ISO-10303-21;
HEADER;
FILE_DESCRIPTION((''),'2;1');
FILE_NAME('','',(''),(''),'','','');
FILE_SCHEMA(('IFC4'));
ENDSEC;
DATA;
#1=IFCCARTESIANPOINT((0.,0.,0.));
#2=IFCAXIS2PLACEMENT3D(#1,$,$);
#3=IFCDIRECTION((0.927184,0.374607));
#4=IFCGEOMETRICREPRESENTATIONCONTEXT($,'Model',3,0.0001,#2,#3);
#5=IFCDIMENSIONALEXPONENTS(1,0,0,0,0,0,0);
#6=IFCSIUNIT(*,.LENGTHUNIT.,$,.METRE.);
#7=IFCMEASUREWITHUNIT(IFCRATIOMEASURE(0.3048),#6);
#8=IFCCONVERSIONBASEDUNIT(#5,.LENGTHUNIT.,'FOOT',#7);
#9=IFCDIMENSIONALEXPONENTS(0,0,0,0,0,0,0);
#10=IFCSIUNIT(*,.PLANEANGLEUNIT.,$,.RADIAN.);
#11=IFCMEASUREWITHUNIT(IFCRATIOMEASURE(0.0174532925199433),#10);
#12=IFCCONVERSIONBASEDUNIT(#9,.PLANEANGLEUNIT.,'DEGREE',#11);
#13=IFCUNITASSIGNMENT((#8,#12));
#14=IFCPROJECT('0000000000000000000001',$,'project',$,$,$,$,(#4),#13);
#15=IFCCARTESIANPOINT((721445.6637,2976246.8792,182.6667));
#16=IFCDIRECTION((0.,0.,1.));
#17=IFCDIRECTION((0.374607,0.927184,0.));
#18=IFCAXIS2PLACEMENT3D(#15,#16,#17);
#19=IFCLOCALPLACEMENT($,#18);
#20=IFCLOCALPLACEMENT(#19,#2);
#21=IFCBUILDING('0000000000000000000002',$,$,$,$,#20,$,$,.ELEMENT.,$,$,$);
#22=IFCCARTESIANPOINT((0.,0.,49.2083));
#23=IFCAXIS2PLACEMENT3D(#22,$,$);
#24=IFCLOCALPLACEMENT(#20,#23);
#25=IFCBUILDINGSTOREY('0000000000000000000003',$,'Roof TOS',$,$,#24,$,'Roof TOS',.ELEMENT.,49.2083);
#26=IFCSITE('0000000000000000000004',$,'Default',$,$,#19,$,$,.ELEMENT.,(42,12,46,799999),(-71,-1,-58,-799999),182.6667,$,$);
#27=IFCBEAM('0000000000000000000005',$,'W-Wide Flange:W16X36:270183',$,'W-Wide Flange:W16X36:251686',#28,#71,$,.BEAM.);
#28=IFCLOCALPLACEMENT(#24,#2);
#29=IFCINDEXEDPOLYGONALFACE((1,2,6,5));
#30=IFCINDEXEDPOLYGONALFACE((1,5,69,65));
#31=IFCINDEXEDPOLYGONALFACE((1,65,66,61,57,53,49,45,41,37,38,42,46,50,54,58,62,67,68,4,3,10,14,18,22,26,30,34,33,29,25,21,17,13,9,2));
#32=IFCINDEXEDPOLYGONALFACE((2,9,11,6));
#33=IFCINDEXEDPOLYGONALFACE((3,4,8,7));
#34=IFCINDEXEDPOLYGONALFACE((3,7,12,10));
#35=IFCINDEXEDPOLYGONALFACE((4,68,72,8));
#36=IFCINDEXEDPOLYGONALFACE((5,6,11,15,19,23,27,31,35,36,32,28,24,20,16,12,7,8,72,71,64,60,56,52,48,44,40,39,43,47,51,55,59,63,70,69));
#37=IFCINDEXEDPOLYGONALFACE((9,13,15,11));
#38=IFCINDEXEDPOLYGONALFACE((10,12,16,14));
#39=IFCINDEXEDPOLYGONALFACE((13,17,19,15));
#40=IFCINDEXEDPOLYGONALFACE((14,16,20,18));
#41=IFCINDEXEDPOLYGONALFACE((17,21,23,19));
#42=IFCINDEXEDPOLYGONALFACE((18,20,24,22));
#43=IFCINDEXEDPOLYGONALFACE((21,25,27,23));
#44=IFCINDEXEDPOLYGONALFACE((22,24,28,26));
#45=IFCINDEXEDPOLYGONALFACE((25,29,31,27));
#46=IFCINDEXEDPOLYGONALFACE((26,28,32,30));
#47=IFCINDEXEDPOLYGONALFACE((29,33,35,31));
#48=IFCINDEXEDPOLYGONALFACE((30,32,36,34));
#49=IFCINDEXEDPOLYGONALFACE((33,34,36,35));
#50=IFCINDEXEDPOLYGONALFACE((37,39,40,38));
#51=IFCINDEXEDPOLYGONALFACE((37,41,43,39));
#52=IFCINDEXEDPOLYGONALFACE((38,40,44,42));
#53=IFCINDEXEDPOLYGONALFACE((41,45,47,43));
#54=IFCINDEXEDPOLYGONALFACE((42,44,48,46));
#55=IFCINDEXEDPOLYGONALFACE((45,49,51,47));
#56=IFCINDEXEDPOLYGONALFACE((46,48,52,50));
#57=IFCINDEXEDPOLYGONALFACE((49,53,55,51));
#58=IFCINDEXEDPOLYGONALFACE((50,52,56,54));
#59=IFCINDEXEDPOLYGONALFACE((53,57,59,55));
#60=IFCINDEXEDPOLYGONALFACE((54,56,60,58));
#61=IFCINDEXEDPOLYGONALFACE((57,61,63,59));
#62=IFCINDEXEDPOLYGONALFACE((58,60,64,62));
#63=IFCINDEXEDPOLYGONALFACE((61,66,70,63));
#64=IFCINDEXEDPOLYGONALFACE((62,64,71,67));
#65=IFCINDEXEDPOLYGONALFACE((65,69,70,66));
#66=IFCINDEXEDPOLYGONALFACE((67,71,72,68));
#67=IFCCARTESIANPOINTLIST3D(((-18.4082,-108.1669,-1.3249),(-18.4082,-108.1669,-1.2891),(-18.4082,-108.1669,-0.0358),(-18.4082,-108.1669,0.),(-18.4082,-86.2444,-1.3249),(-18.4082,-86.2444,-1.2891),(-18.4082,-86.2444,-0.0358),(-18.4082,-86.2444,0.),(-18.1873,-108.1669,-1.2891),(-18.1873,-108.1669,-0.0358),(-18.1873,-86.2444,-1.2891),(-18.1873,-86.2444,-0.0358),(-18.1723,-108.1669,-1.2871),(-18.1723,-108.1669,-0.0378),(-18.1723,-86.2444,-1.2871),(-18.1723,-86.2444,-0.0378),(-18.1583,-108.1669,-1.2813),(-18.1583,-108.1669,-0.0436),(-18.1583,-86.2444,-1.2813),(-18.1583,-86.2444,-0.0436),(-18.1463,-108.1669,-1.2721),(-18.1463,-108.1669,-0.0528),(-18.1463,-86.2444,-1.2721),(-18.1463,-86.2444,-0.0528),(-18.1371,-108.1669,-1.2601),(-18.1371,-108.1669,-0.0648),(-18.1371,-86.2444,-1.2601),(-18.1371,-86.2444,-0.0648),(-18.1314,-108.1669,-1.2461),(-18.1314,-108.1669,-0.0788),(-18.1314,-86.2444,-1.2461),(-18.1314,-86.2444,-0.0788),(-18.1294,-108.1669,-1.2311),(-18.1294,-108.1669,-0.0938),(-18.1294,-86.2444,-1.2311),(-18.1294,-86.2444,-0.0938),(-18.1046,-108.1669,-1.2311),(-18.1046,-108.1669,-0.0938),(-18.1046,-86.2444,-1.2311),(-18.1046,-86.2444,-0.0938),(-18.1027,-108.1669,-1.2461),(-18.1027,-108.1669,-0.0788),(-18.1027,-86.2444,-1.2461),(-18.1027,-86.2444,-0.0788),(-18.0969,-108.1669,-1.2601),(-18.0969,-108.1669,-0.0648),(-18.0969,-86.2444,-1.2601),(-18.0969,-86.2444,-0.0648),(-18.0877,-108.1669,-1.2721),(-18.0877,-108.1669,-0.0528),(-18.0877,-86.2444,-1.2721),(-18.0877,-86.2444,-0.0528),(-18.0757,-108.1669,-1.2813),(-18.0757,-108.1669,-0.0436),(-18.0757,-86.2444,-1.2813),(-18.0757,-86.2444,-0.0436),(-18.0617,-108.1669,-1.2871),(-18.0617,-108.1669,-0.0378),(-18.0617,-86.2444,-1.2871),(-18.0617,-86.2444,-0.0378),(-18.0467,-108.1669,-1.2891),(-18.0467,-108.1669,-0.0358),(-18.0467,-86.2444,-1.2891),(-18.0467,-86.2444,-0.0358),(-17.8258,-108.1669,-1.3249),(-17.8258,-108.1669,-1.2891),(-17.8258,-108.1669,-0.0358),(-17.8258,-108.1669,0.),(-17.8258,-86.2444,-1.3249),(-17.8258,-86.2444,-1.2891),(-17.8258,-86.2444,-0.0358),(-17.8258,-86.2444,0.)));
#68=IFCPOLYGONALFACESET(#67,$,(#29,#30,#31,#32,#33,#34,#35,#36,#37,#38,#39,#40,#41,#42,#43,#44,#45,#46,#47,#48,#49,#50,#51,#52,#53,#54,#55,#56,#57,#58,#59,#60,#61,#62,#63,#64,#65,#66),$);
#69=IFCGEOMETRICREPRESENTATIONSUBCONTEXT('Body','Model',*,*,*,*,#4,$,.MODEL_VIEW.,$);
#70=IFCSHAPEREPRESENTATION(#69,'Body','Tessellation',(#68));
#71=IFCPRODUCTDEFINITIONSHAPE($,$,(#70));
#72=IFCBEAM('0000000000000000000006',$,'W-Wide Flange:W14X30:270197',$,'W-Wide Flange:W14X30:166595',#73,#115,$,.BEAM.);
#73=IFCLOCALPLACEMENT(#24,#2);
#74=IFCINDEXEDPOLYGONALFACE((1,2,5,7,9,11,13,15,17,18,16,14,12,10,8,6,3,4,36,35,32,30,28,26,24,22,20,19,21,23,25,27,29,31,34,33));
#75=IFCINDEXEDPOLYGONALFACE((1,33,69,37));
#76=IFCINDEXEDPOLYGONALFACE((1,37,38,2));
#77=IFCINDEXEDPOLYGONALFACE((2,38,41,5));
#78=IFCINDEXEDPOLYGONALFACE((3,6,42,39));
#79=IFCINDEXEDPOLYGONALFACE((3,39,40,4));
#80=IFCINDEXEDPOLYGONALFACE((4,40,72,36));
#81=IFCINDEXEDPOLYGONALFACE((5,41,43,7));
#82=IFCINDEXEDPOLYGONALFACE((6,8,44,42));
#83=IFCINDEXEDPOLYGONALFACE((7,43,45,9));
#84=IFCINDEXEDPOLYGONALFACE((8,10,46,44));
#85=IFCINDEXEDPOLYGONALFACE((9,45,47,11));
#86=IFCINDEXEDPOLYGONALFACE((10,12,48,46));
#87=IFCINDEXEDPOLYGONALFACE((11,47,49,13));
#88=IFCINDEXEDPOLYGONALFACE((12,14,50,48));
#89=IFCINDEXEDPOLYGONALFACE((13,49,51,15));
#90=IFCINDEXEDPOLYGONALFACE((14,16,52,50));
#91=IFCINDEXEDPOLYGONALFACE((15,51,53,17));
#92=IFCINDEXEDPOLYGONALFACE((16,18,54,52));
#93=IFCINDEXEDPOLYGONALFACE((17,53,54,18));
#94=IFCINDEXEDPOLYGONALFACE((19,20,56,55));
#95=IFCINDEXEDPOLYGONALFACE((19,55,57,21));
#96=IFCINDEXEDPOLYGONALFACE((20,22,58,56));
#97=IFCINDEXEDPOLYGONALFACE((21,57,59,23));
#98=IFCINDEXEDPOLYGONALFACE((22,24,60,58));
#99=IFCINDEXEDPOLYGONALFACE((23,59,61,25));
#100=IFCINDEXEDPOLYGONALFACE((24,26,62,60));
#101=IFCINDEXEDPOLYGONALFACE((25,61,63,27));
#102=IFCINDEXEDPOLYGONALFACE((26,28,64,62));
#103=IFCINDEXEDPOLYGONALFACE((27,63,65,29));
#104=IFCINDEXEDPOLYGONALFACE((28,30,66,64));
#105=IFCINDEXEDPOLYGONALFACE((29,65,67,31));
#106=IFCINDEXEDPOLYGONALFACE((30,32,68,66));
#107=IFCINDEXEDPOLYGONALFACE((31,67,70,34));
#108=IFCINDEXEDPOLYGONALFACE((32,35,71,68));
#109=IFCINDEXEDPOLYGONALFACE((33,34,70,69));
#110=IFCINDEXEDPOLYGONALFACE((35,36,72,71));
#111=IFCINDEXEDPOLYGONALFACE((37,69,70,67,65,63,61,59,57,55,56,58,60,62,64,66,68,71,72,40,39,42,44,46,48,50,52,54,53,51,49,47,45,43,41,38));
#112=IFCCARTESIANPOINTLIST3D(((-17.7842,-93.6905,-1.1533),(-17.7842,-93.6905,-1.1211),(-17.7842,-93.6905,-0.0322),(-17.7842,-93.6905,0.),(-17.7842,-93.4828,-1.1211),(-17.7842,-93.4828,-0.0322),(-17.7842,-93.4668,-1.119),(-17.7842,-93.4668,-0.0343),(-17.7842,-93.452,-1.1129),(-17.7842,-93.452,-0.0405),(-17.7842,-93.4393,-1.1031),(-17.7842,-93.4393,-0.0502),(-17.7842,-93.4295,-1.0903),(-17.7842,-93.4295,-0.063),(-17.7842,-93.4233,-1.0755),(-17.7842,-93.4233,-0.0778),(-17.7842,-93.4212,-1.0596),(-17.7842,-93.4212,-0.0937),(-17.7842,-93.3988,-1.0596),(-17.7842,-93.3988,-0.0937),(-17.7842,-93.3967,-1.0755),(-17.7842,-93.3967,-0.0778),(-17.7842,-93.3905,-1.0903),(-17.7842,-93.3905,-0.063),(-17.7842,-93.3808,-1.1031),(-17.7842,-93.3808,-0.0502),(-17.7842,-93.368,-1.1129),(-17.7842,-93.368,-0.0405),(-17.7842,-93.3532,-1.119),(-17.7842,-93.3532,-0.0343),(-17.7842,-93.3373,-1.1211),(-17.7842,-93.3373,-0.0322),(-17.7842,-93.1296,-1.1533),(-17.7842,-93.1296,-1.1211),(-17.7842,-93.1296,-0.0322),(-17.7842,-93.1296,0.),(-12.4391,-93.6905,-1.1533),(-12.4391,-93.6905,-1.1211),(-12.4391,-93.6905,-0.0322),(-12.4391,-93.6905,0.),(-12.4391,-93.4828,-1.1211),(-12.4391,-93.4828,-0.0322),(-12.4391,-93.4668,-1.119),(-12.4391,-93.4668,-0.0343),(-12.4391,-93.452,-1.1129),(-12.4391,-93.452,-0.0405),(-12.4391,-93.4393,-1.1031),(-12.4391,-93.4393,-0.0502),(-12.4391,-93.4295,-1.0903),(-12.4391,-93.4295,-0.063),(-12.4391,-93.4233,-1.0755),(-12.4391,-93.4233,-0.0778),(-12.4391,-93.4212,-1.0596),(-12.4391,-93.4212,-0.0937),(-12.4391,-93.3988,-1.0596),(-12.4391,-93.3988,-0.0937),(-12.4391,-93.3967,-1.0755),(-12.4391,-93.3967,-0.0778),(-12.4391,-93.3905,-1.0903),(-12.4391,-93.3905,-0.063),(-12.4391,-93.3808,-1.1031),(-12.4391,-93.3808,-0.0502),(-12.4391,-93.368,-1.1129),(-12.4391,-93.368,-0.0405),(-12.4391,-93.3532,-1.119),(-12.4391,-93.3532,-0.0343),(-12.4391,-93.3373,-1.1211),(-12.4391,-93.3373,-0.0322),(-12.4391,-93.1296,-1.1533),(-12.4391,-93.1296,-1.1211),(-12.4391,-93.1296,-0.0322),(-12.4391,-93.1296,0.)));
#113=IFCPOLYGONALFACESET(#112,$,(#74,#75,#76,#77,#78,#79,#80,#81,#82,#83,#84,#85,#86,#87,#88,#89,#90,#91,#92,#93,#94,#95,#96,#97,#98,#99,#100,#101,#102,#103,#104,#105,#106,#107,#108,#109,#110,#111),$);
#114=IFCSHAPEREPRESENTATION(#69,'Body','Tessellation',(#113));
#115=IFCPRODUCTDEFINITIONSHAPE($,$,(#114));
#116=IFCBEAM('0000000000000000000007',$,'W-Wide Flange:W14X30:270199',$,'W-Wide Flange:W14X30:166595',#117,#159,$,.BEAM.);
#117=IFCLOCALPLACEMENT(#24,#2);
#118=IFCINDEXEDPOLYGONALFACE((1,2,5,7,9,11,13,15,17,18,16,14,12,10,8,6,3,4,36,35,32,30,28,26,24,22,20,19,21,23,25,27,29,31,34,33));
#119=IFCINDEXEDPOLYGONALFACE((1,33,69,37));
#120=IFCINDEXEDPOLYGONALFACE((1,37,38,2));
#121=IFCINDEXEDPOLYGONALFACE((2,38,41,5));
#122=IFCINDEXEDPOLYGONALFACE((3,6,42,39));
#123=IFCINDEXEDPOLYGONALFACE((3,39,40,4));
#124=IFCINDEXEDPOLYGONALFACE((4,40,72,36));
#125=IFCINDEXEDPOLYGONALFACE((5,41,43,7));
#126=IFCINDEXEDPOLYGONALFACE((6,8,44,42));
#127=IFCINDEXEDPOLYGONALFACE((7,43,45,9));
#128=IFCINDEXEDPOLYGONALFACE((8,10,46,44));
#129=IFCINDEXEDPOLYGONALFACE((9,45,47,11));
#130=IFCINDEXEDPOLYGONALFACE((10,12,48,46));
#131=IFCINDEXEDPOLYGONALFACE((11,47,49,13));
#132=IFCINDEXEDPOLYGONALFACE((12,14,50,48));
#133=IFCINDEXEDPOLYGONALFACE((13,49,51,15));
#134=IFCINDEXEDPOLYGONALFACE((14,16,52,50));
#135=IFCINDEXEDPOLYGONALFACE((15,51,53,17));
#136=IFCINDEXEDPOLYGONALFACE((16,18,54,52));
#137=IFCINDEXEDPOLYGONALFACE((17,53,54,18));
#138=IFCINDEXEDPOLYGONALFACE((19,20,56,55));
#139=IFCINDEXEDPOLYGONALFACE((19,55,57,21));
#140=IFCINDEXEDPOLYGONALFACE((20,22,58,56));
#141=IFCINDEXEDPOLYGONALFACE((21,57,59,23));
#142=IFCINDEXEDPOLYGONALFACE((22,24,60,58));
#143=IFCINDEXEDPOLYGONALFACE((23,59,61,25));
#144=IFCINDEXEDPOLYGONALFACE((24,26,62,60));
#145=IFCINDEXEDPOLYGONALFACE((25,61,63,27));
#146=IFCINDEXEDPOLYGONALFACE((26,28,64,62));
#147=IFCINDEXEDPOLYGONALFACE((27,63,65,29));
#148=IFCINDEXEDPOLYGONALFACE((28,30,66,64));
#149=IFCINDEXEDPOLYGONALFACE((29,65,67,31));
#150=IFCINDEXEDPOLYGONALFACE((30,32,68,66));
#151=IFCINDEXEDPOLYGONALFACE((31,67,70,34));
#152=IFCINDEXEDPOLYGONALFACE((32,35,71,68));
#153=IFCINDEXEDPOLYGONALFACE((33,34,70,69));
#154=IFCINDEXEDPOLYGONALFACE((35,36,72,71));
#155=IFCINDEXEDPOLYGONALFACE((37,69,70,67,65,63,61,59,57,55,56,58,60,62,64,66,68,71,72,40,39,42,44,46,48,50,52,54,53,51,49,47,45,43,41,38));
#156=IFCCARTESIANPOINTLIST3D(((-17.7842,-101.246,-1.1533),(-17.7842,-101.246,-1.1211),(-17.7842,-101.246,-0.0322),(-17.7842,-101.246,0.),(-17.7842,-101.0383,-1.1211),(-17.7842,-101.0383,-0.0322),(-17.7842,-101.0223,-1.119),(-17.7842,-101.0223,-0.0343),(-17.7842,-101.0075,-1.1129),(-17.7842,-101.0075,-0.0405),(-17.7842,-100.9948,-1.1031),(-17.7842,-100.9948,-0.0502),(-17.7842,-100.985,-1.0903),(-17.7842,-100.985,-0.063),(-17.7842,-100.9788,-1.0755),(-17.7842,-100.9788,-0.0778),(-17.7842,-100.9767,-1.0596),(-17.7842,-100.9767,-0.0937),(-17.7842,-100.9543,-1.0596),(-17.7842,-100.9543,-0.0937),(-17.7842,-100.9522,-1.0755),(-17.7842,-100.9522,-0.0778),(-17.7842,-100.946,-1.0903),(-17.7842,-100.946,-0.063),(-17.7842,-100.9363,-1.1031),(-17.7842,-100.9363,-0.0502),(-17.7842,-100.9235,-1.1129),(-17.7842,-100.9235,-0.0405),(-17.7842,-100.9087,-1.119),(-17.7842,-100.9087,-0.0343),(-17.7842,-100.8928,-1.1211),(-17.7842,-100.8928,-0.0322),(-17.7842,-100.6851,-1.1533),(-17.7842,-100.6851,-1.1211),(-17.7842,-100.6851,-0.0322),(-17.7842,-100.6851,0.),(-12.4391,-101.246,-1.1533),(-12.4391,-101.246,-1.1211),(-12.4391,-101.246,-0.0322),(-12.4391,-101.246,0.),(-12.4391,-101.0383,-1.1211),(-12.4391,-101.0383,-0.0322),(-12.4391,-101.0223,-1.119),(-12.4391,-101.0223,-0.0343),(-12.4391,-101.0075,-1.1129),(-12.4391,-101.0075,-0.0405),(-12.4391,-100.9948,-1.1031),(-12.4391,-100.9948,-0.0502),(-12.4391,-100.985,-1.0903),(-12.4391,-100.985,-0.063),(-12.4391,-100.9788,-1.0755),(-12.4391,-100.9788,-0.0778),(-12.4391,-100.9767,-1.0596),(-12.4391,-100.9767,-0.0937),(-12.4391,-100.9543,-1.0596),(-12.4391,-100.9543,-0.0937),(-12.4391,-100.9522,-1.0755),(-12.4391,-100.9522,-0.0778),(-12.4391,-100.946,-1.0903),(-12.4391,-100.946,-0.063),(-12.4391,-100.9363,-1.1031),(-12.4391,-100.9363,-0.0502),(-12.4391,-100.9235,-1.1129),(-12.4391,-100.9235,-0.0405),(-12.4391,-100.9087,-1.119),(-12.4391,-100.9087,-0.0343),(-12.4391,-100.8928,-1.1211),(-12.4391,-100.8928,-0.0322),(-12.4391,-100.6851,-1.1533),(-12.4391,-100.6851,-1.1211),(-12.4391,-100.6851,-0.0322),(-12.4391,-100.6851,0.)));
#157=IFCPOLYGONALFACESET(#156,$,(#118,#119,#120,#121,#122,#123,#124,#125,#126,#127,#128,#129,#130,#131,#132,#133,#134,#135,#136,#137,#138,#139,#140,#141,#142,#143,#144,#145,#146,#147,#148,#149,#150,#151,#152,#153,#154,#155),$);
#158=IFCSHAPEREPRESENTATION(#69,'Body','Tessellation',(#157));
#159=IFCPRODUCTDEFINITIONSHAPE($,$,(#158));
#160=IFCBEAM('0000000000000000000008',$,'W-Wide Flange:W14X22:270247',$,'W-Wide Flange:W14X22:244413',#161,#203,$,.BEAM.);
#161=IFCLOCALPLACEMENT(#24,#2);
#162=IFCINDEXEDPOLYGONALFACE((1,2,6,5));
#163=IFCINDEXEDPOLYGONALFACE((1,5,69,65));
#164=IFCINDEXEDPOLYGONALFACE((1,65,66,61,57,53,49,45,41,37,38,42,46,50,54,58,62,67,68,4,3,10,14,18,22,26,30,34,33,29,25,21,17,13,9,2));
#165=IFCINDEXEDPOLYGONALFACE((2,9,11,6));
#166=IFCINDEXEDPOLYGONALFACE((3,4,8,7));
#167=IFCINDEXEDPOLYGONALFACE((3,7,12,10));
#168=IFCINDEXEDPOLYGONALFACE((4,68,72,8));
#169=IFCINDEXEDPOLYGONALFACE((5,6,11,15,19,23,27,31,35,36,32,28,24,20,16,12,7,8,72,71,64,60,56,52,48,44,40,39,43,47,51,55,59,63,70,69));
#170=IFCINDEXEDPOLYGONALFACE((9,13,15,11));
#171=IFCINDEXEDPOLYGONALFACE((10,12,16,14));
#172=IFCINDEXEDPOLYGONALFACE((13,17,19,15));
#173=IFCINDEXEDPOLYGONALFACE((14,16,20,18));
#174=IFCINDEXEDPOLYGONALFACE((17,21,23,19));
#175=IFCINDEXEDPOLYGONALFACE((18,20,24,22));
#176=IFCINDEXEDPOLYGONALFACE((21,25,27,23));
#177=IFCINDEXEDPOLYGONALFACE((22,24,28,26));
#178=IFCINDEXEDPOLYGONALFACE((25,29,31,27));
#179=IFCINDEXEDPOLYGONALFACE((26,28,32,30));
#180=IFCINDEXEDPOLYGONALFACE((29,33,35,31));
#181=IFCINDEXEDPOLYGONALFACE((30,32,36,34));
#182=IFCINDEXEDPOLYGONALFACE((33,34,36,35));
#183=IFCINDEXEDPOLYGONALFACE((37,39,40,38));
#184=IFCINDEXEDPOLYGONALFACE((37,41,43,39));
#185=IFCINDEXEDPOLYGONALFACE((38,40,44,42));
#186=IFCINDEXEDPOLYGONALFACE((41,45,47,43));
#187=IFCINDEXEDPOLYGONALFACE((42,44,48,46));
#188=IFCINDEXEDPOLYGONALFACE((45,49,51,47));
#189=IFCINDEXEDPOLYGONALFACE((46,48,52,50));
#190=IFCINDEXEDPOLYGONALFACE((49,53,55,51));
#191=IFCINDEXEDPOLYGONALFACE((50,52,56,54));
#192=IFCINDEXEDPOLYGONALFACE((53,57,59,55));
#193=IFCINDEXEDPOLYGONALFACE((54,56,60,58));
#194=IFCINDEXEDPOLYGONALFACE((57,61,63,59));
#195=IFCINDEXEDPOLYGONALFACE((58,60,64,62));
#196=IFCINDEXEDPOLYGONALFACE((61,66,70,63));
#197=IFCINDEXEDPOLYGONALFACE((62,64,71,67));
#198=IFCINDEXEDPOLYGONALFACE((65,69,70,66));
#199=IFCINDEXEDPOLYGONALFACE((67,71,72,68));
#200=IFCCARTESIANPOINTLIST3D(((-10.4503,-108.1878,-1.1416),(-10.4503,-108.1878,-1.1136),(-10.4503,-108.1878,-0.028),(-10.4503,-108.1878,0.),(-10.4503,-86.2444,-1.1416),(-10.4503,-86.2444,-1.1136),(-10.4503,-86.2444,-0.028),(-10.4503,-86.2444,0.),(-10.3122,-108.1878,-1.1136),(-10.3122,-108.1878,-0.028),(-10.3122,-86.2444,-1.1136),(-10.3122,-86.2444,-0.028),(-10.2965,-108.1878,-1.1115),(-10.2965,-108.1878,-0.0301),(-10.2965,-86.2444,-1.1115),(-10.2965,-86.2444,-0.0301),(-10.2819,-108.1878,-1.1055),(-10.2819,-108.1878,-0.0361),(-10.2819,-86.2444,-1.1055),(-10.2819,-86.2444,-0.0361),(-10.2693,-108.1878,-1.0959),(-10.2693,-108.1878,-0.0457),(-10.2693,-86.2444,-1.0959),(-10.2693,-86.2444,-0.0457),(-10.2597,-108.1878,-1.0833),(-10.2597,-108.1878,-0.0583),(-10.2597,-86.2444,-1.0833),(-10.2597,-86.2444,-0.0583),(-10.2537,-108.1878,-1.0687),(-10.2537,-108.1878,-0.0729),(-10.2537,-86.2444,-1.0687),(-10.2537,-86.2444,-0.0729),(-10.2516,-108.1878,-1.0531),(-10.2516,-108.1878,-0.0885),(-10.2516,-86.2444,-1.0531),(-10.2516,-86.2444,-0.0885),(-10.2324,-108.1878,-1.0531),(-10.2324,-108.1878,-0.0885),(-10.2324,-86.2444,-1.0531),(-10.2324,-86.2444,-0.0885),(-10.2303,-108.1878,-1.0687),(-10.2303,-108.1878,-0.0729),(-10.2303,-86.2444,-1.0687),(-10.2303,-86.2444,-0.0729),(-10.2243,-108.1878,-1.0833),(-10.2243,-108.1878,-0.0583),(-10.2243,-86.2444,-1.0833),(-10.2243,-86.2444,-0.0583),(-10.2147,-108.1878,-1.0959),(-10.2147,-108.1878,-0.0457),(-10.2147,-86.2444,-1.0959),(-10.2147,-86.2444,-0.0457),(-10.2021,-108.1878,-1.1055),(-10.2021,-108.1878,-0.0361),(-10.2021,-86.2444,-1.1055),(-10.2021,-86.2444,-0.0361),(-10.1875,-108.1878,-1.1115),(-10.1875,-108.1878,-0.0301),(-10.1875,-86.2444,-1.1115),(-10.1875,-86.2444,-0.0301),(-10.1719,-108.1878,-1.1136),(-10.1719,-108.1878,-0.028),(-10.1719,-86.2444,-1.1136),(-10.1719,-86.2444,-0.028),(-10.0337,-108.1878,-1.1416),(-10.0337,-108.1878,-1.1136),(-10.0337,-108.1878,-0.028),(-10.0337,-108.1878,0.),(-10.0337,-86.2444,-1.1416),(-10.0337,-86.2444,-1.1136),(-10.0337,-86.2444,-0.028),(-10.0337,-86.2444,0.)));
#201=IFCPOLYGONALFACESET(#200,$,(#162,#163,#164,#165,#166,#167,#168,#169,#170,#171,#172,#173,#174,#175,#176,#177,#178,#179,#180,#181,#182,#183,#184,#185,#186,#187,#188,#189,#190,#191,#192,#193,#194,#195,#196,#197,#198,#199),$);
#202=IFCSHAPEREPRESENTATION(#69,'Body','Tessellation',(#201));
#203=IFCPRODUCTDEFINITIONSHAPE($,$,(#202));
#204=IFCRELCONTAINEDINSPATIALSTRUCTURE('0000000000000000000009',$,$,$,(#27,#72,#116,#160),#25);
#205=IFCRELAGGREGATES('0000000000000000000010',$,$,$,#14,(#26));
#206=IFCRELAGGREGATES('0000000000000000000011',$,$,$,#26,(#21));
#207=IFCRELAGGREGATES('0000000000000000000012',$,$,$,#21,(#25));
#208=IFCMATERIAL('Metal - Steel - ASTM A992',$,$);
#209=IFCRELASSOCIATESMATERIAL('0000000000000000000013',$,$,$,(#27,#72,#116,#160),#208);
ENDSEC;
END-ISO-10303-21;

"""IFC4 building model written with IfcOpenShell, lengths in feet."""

from ifc_helpers import new_model, entity, si_unit, converted_unit, direction, frame, frame_2d, origin, place, context, subcontext, project, spatial, i_section, extrude, material, element, save


model = new_model("IFC4")

# Units and contexts
model_context = context("Model", 3, precision=0.0001, world=origin(), true_north=direction((0.927184, 0.374607)))
body_context = subcontext(model_context, "Body", "Model", "MODEL_VIEW")
ifc_project = project(units=[converted_unit("LENGTHUNIT", "FOOT", entity("IfcRatioMeasure", 0.3048), si_unit("LENGTHUNIT", "METRE"), dimensions=[1, 0, 0, 0, 0, 0, 0]), converted_unit("PLANEANGLEUNIT", "DEGREE", entity("IfcRatioMeasure", 0.0174532925199433), si_unit("PLANEANGLEUNIT", "RADIAN"), dimensions=[0, 0, 0, 0, 0, 0, 0])], contexts=[model_context])

# Site, building, storey
site_placement = place(None, frame((721445.6637, 2976246.8792, 182.6667), z_axis=(0.0, 0.0, 1.0), x_axis=(0.374607, 0.927184, 0.0)))
site = spatial("IfcSite", under=ifc_project, at=site_placement, Name="Default", CompositionType="ELEMENT", RefLatitude=(42, 12, 46, 799999), RefLongitude=(-71, -1, -58, -799999), RefElevation=182.6667)
building_placement = place(site_placement, origin())
building = spatial("IfcBuilding", under=site, at=building_placement, CompositionType="ELEMENT")
storey_placement = place(building_placement, frame((0.0, 0.0, 49.2083)))
storey = spatial("IfcBuildingStorey", under=building, at=storey_placement, Name="Roof TOS", LongName="Roof TOS", CompositionType="ELEMENT", Elevation=49.2083)

# Beams
ifc_material = material(Name="Metal - Steel - ASTM A992")
beam_1_placement = place(storey_placement, frame((-18.117, -85.8544, 0.0), z_axis=(0.0, 0.0, 1.0), x_axis=(0.0, -1.0, 0.0)))
element("IfcBeam", 1, at=beam_1_placement, inside=storey, material=ifc_material, Name="W-Wide Flange:W16X36:270183", ObjectType="W-Wide Flange:W16X36:251686", PredefinedType="BEAM", context=body_context, shape_type="SweptSolid", body=[
    extrude(i_section(OverallWidth=0.5824, OverallDepth=1.3249, WebThickness=0.0247, FlangeThickness=0.0358, FilletRadius=0.0579, at=frame_2d((0.0, 0.0), x_axis=(0.0, 1.0))), frame((0.39, 0.0, -0.6624), z_axis=(1.0, 0.0, 0.0), x_axis=(0.0, 0.0, -1.0)), (0.0, 0.0, 1.0), 21.9225),
])
beam_2_placement = place(storey_placement, frame((-18.117, -93.41, 0.0)))
element("IfcBeam", 2, at=beam_2_placement, inside=storey, material=ifc_material, Name="W-Wide Flange:W14X30:270197", ObjectType="W-Wide Flange:W14X30:166595", PredefinedType="BEAM", context=body_context, shape_type="SweptSolid", body=[
    extrude(i_section(OverallWidth=0.5609, OverallDepth=1.1533, WebThickness=0.0225, FlangeThickness=0.0322, FilletRadius=0.0615, at=frame_2d((0.0, 0.0), x_axis=(0.0, 1.0))), frame((0.3328, 0.0, -0.5767), z_axis=(1.0, 0.0, 0.0), x_axis=(0.0, 0.0, -1.0)), (0.0, 0.0, 1.0), 5.3451),
])
beam_3_placement = place(storey_placement, frame((-18.117, -100.9655, 0.0)))
element("IfcBeam", 3, at=beam_3_placement, inside=storey, material=ifc_material, Name="W-Wide Flange:W14X30:270199", ObjectType="W-Wide Flange:W14X30:166595", PredefinedType="BEAM", context=body_context, shape_type="SweptSolid", body=[
    extrude(i_section(OverallWidth=0.5609, OverallDepth=1.1533, WebThickness=0.0225, FlangeThickness=0.0322, FilletRadius=0.0615, at=frame_2d((0.0, 0.0), x_axis=(0.0, 1.0))), frame((0.3328, 0.0, -0.5767), z_axis=(1.0, 0.0, 0.0), x_axis=(0.0, 0.0, -1.0)), (0.0, 0.0, 1.0), 5.3451),
])
beam_4_placement = place(storey_placement, frame((-10.242, -85.8544, 0.0), z_axis=(0.0, 0.0, 1.0), x_axis=(0.0, -1.0, 0.0)))
element("IfcBeam", 4, at=beam_4_placement, inside=storey, material=ifc_material, Name="W-Wide Flange:W14X22:270247", ObjectType="W-Wide Flange:W14X22:244413", PredefinedType="BEAM", context=body_context, shape_type="SweptSolid", body=[
    extrude(i_section(OverallWidth=0.4167, OverallDepth=1.1416, WebThickness=0.0192, FlangeThickness=0.028, FilletRadius=0.0605, at=frame_2d((0.0, 0.0), x_axis=(0.0, 1.0))), frame((0.39, 0.0, -0.5708), z_axis=(1.0, 0.0, 0.0), x_axis=(0.0, 0.0, -1.0)), (0.0, 0.0, 1.0), 21.9434),
])

save(model, "model.ifc")
